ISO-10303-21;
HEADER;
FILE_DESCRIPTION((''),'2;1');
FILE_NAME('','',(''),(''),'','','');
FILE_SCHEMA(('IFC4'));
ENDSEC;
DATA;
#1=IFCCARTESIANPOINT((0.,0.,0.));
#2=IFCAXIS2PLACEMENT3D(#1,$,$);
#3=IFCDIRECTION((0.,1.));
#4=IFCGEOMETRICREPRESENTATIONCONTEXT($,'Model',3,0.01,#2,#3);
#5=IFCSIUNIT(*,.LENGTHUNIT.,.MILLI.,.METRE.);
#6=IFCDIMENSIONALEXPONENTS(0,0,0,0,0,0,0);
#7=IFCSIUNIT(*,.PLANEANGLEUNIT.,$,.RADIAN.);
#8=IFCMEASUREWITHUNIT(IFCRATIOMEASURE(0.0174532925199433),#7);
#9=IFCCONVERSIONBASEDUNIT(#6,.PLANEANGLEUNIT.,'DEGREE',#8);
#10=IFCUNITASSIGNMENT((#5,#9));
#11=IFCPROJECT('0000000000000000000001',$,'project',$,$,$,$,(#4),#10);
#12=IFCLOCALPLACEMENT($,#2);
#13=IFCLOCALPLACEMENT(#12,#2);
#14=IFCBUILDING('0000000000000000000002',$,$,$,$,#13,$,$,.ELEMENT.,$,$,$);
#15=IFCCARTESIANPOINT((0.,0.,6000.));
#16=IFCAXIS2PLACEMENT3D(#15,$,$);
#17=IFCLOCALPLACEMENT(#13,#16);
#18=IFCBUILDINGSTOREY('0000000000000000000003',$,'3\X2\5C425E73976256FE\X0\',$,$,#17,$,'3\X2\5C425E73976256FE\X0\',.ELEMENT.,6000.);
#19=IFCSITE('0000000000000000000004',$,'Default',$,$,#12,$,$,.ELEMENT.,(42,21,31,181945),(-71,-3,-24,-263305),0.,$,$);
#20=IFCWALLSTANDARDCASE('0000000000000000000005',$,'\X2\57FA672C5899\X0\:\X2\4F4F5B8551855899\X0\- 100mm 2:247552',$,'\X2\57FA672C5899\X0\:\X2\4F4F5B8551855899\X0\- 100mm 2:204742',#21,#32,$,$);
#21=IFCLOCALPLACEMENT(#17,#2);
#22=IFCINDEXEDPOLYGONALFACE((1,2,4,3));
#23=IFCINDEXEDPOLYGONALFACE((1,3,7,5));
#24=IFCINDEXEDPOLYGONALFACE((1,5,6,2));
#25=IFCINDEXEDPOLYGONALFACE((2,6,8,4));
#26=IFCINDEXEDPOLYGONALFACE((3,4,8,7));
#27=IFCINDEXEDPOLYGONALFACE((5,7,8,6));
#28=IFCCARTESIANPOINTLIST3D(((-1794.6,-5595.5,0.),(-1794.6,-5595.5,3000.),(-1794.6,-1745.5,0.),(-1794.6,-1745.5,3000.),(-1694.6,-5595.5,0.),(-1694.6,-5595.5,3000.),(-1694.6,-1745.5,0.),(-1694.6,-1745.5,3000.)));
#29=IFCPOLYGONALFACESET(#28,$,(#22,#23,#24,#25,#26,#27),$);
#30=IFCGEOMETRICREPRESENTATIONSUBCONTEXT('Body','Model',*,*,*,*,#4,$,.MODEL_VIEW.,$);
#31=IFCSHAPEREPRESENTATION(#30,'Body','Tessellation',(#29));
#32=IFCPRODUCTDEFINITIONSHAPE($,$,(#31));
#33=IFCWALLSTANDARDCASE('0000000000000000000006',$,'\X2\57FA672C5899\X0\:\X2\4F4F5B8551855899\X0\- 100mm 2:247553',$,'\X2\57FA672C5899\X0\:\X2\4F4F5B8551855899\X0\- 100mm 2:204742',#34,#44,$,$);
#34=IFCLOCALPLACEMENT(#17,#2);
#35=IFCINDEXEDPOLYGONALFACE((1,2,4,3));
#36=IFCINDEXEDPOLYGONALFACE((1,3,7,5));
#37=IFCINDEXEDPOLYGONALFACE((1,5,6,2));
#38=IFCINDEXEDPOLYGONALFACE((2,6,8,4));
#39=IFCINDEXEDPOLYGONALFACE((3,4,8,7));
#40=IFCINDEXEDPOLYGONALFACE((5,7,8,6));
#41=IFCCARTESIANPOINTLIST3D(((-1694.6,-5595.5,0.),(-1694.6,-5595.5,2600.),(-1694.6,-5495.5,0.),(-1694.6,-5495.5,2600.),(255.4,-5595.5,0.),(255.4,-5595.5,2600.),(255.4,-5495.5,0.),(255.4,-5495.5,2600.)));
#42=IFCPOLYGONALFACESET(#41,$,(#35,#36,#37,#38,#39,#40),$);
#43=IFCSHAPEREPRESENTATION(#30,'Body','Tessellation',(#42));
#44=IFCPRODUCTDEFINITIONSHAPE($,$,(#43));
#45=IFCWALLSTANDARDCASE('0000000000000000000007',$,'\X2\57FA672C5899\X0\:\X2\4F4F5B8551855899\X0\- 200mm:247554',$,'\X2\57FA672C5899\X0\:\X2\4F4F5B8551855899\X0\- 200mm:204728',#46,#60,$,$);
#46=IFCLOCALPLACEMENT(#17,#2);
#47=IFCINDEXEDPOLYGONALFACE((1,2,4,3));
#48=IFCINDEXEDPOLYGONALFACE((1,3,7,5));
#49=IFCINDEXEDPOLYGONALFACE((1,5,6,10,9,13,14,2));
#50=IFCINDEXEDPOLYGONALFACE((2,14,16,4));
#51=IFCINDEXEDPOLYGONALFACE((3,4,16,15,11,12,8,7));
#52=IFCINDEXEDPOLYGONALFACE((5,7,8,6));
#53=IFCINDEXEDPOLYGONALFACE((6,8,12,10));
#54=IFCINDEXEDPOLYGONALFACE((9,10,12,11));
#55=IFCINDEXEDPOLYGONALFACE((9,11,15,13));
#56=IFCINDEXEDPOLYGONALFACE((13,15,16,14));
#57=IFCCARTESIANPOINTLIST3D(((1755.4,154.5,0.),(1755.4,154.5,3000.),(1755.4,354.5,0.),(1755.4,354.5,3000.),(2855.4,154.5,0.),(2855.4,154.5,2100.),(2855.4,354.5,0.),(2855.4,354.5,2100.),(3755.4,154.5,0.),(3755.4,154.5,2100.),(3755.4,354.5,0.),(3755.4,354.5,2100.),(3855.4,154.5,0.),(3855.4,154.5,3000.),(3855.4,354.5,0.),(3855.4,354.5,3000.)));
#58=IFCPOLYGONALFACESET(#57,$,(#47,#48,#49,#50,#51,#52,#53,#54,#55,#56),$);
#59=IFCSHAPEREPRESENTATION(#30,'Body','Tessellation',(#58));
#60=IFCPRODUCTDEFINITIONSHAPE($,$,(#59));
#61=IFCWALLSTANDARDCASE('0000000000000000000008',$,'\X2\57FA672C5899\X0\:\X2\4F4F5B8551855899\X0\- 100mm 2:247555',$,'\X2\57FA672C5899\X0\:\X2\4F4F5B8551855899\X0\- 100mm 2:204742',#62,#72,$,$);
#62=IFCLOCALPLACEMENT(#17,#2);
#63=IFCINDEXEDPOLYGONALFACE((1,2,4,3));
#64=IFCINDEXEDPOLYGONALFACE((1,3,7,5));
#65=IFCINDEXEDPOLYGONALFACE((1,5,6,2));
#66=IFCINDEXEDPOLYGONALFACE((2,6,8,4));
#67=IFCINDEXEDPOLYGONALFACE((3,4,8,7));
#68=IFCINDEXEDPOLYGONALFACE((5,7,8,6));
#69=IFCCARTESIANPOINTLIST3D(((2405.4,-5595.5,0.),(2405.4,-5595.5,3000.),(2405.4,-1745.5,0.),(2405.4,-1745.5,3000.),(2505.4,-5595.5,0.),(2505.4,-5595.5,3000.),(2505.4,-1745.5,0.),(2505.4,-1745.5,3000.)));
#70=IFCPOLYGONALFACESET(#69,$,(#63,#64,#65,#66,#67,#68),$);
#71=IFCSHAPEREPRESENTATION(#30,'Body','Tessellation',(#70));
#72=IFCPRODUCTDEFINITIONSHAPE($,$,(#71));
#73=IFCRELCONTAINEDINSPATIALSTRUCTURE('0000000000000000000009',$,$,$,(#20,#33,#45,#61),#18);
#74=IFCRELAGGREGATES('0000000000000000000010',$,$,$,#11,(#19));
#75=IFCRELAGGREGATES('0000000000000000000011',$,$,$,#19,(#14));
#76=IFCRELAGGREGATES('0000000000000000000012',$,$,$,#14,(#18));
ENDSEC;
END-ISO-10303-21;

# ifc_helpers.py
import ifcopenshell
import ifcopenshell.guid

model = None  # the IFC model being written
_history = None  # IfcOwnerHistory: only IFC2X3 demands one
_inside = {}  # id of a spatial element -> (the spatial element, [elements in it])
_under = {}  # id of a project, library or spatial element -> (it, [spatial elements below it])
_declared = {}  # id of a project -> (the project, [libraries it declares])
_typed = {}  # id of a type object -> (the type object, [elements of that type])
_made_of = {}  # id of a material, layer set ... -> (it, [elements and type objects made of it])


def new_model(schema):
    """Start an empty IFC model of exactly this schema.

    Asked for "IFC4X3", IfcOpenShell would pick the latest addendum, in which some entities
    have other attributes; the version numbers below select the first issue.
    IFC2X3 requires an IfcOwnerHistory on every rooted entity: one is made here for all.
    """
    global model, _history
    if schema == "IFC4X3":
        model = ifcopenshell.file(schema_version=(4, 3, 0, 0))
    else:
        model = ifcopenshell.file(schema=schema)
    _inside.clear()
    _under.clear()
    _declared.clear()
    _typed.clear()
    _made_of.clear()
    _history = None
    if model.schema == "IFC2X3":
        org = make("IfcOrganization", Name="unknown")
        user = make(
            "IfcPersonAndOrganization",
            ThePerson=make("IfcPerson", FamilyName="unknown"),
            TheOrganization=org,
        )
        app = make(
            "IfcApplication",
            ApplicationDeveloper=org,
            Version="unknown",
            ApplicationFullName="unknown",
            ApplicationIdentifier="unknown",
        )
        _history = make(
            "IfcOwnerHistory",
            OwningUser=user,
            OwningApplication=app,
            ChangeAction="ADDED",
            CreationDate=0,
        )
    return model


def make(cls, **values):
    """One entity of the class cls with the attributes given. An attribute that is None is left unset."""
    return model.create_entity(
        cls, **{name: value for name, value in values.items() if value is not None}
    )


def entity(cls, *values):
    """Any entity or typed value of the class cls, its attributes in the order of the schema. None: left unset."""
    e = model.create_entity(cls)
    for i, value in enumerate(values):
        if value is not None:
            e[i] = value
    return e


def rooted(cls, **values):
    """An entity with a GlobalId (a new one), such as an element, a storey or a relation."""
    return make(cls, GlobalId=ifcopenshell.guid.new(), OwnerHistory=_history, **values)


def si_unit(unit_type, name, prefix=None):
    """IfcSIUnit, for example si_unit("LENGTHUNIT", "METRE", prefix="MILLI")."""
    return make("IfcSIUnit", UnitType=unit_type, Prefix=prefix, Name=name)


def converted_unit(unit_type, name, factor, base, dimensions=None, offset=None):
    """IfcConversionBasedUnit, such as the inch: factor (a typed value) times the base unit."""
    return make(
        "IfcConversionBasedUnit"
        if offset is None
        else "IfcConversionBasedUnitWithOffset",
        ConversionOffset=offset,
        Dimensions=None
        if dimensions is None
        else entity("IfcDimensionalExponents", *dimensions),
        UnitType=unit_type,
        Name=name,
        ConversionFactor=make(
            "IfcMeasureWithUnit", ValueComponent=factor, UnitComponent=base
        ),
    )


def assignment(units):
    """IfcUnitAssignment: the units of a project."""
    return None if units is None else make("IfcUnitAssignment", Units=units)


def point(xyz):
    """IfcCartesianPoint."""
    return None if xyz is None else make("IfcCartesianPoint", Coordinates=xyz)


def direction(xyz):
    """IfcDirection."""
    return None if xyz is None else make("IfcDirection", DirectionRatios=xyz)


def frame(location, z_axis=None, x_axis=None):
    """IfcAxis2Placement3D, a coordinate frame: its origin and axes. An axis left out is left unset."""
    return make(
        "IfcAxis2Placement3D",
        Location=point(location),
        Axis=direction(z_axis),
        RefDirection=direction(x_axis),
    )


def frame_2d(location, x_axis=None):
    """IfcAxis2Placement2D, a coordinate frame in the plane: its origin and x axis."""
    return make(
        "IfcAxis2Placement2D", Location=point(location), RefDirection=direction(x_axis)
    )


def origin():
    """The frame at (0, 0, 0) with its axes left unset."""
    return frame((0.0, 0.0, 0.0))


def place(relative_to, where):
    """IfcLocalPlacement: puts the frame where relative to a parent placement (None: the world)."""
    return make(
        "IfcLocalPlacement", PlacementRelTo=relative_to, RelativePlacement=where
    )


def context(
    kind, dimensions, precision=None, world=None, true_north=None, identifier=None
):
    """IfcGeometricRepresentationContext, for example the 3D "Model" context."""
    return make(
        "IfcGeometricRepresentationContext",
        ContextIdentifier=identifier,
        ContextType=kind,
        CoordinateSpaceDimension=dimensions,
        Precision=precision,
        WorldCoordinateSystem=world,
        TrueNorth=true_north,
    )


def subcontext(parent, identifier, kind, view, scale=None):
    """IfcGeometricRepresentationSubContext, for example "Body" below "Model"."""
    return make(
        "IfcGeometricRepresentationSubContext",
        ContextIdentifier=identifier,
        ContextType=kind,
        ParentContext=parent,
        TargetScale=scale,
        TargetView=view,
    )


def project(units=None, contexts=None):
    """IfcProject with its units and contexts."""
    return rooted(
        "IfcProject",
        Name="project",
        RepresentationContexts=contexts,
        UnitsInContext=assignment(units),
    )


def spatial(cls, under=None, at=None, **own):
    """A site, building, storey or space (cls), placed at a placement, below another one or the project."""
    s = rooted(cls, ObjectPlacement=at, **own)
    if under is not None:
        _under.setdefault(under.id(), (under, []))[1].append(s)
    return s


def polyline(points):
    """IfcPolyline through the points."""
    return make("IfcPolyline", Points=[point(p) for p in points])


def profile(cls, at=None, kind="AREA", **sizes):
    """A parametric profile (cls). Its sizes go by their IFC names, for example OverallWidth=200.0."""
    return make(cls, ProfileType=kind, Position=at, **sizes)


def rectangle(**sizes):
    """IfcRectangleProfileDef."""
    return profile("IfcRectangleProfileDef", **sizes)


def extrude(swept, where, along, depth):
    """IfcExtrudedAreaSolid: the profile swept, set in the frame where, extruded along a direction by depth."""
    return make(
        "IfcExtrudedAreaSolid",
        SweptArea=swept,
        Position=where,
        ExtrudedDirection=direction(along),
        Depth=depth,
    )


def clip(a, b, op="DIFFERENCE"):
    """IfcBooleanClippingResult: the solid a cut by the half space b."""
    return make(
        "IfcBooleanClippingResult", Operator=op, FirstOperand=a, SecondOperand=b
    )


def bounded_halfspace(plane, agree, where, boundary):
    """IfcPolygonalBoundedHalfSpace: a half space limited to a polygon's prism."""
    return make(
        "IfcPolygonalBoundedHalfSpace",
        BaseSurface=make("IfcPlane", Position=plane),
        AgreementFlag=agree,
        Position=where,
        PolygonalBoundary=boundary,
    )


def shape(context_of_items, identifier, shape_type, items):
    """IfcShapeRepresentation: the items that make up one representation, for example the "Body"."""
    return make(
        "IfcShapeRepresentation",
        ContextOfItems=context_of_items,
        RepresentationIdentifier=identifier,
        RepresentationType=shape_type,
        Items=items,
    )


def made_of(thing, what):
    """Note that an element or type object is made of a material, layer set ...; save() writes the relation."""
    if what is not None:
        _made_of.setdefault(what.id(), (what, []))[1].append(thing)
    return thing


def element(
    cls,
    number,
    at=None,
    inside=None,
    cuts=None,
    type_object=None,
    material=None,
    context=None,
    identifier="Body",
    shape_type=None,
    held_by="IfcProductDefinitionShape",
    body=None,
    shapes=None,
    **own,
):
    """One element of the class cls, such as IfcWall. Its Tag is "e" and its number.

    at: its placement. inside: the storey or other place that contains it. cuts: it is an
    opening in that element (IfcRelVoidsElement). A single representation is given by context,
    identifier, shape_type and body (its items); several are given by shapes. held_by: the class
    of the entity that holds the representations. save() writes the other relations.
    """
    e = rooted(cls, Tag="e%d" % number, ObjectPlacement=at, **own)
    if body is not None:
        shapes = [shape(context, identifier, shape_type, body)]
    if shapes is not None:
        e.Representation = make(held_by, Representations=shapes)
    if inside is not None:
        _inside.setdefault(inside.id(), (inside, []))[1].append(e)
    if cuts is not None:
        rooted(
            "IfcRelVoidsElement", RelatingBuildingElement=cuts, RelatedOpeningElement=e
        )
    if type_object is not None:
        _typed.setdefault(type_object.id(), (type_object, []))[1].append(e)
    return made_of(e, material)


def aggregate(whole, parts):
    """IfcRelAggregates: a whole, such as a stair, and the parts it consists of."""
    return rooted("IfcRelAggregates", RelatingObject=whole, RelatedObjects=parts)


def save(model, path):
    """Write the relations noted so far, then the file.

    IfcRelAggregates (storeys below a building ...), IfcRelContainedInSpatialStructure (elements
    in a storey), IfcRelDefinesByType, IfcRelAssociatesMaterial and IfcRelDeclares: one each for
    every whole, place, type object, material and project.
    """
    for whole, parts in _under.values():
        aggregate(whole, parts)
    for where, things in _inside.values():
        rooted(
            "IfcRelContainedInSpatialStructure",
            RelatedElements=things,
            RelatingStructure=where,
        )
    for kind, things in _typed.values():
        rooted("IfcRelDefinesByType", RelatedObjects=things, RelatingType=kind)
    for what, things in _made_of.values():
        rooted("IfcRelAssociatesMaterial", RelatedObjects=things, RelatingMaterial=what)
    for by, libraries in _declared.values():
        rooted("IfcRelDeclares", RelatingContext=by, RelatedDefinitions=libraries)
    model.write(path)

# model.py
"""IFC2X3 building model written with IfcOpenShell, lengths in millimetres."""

from ifc_helpers import new_model, entity, si_unit, converted_unit, direction, frame, frame_2d, origin, place, context, subcontext, project, spatial, polyline, rectangle, extrude, clip, bounded_halfspace, element, save


model = new_model("IFC2X3")

# Units and contexts
model_context = context("Model", 3, precision=0.01, world=origin(), true_north=direction((0.0, 1.0)))
body_context = subcontext(model_context, "Body", "Model", "MODEL_VIEW")
ifc_project = project(units=[si_unit("LENGTHUNIT", "METRE", prefix="MILLI"), converted_unit("PLANEANGLEUNIT", "DEGREE", entity("IfcRatioMeasure", 0.0174532925199433), si_unit("PLANEANGLEUNIT", "RADIAN"), dimensions=[0, 0, 0, 0, 0, 0, 0])], contexts=[model_context])

# Site, building, storey
site_placement = place(None, origin())
site = spatial("IfcSite", under=ifc_project, at=site_placement, Name="Default", CompositionType="ELEMENT", RefLatitude=(42, 21, 31, 181945), RefLongitude=(-71, -3, -24, -263305), RefElevation=0.0)
building_placement = place(site_placement, origin())
building = spatial("IfcBuilding", under=site, at=building_placement, CompositionType="ELEMENT")
storey_placement = place(building_placement, frame((0.0, 0.0, 6000.0)))
storey = spatial("IfcBuildingStorey", under=building, at=storey_placement, Name="3层平面图", LongName="3层平面图", CompositionType="ELEMENT", Elevation=6000.0)

# Walls
wall_1_placement = place(storey_placement, frame((-1744.6, -1745.5, 0.0), z_axis=(0.0, 0.0, 1.0), x_axis=(0.0, -1.0, 0.0)))
element("IfcWallStandardCase", 1, at=wall_1_placement, inside=storey, Name="基本墙:住宅内墙- 100mm 2:247552", ObjectType="基本墙:住宅内墙- 100mm 2:204742", context=body_context, shape_type="SweptSolid", body=[
    extrude(rectangle(XDim=3850.0, YDim=100.0, at=frame_2d((1925.0, 0.0), x_axis=(-1.0, 0.0))), origin(), (0.0, 0.0, 1.0), 3000.0),
])
wall_2_placement = place(storey_placement, frame((-1694.6, -5545.5, 0.0)))
element("IfcWallStandardCase", 2, at=wall_2_placement, inside=storey, Name="基本墙:住宅内墙- 100mm 2:247553", ObjectType="基本墙:住宅内墙- 100mm 2:204742", context=body_context, shape_type="Clipping", body=[
    clip(extrude(rectangle(XDim=1950.0, YDim=100.0, at=frame_2d((975.0, 0.0), x_axis=(-1.0, 0.0))), origin(), (0.0, 0.0, 1.0), 2600.0), bounded_halfspace(frame((0.0, -50.0, 2600.0), z_axis=(0.0, 0.0, -1.0), x_axis=(-1.0, 0.0, 0.0)), True, frame((0.0, -50.0, 2600.0), z_axis=(0.0, 0.0, -1.0), x_axis=(-1.0, 0.0, 0.0)), polyline([(0.0, 0.0), (0.0, 100.0), (-1950.0, 100.0), (-1950.0, 0.0), (0.0, 0.0)]))),
])

# Wall, opening
wall_3_placement = place(storey_placement, frame((3855.4, 254.5, 0.0), z_axis=(0.0, 0.0, 1.0), x_axis=(-1.0, 0.0, 0.0)))
wall_3 = element("IfcWallStandardCase", 3, at=wall_3_placement, inside=storey, Name="基本墙:住宅内墙- 200mm:247554", ObjectType="基本墙:住宅内墙- 200mm:204728", context=body_context, shape_type="SweptSolid", body=[
    extrude(rectangle(XDim=2100.0, YDim=200.0, at=frame_2d((1050.0, 0.0), x_axis=(-1.0, 0.0))), origin(), (0.0, 0.0, 1.0), 3000.0),
])
opening_placement = place(wall_3_placement, frame((1000.0, 100.0, 0.0)))
element("IfcOpeningElement", 4, at=opening_placement, cuts=wall_3, ObjectType="Opening", context=body_context, shape_type="SweptSolid", body=[
    extrude(rectangle(XDim=2100.0, YDim=900.0, at=frame_2d((1050.0, 450.0), x_axis=(1.0, 0.0))), frame((0.0, 0.0, 0.0), z_axis=(0.0, -1.0, 0.0), x_axis=(0.0, 0.0, 1.0)), (0.0, 0.0, 1.0), 200.0),
])

# Wall
wall_4_placement = place(storey_placement, frame((2455.4, -1745.5, 0.0), z_axis=(0.0, 0.0, 1.0), x_axis=(0.0, -1.0, 0.0)))
element("IfcWallStandardCase", 5, at=wall_4_placement, inside=storey, Name="基本墙:住宅内墙- 100mm 2:247555", ObjectType="基本墙:住宅内墙- 100mm 2:204742", context=body_context, shape_type="SweptSolid", body=[
    extrude(rectangle(XDim=3850.0, YDim=100.0, at=frame_2d((1925.0, 0.0), x_axis=(-1.0, 0.0))), origin(), (0.0, 0.0, 1.0), 3000.0),
])

save(model, "model.ifc")
